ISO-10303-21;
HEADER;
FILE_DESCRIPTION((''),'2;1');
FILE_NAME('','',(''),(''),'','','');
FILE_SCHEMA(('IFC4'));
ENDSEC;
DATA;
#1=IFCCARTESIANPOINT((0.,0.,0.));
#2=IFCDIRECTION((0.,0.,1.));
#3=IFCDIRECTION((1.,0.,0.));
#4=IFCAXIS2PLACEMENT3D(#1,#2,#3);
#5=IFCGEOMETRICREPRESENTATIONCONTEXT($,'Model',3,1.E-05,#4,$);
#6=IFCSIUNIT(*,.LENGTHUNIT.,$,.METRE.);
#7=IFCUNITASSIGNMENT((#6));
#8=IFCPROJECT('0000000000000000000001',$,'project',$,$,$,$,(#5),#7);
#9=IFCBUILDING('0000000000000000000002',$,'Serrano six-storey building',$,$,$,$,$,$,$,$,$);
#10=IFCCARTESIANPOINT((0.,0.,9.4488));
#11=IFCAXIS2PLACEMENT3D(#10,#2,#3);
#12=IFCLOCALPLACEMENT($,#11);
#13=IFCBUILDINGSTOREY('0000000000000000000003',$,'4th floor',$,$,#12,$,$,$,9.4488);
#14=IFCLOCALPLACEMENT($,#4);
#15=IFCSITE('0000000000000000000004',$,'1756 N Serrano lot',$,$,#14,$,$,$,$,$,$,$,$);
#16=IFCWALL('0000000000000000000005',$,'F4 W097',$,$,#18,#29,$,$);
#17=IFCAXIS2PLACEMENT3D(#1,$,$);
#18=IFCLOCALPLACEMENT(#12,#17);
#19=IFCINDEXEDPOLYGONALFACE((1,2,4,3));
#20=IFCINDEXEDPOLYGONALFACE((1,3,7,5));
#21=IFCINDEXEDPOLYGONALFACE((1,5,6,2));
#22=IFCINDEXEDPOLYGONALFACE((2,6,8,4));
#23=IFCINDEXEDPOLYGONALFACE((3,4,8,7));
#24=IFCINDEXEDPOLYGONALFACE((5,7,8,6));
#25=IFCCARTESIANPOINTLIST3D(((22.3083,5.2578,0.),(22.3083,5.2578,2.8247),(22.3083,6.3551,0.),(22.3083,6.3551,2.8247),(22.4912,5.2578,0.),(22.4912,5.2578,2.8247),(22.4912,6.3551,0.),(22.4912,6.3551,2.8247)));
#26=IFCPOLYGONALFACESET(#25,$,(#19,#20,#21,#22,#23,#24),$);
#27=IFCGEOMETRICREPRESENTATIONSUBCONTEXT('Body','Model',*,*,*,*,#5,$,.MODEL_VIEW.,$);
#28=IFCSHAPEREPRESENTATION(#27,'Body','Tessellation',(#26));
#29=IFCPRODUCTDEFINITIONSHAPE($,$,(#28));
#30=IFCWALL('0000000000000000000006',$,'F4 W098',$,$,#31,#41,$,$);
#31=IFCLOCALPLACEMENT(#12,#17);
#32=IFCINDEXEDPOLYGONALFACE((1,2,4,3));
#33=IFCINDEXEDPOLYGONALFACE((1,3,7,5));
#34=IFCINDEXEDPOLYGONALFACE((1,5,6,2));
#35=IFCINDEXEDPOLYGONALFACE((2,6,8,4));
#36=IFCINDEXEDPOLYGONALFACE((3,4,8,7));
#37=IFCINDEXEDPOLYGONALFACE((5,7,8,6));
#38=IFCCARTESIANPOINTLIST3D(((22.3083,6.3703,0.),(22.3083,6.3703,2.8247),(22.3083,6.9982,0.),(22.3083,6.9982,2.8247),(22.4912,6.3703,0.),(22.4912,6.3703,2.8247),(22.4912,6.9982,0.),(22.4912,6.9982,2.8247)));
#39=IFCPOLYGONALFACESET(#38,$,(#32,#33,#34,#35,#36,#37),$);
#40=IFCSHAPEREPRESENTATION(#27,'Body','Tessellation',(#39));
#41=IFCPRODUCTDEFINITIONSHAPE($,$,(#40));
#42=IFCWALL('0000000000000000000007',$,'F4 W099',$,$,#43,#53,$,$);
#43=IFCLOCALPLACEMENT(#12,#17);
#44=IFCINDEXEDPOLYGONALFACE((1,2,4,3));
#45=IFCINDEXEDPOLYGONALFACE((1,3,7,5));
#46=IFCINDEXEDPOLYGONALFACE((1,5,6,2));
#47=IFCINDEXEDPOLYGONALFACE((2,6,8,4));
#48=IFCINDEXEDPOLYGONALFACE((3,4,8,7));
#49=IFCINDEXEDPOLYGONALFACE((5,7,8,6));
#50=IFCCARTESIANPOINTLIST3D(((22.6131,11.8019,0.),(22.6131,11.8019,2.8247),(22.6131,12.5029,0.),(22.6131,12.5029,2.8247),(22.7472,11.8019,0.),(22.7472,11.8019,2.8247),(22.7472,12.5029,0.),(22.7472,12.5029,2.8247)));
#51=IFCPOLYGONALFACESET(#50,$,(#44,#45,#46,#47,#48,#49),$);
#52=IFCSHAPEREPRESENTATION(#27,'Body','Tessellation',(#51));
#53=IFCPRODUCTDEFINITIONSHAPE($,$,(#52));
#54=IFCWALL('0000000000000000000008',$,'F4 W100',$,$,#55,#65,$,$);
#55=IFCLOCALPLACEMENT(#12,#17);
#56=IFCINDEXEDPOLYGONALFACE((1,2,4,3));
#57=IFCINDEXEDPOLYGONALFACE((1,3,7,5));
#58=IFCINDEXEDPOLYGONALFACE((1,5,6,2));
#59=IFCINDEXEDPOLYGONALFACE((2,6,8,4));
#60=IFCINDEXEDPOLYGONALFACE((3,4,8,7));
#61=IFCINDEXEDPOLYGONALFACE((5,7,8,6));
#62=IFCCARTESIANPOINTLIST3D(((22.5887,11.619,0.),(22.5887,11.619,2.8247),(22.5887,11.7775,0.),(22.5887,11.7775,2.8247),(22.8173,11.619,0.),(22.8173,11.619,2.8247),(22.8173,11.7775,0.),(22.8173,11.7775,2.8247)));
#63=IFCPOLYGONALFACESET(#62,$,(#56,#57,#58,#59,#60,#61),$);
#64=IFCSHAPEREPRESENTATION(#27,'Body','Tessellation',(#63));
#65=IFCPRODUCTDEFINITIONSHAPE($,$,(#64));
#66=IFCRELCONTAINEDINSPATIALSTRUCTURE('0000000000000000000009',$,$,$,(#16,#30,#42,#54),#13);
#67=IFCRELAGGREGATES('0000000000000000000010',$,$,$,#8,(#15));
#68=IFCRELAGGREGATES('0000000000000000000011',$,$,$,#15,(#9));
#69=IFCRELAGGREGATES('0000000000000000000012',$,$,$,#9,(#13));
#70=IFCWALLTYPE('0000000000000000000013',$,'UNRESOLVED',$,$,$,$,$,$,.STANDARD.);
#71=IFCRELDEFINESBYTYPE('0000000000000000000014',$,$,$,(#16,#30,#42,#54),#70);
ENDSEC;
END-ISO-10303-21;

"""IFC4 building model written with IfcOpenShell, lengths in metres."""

from ifc_helpers import new_model, si_unit, frame, origin_with_axes, place, context, subcontext, project, spatial, polyline, outline, extrude, type_object, element, save


model = new_model("IFC4")

# Units and contexts
model_context = context("Model", 3, precision=1e-05, world=origin_with_axes())
body_context = subcontext(model_context, "Body", "Model", "MODEL_VIEW")
ifc_project = project(units=[si_unit("LENGTHUNIT", "METRE")], contexts=[model_context])

# Site, building, storey
site_placement = place(None, origin_with_axes())
site = spatial("IfcSite", under=ifc_project, at=site_placement, Name="1756 N Serrano lot")
building = spatial("IfcBuilding", under=site, Name="Serrano six-storey building")
storey_placement = place(None, frame((0.0, 0.0, 9.4488), z_axis=(0.0, 0.0, 1.0), x_axis=(1.0, 0.0, 0.0)))
storey = spatial("IfcBuildingStorey", under=building, at=storey_placement, Name="4th floor", Elevation=9.4488)

# Walls
wall_type_1 = type_object("IfcWallType", Name="UNRESOLVED", PredefinedType="STANDARD")
wall_1_placement = place(storey_placement, frame((0.0, 0.0, -9.4488), z_axis=(0.0, 0.0, 1.0), x_axis=(1.0, 0.0, 0.0)))
element("IfcWall", 1, at=wall_1_placement, inside=storey, type_object=wall_type_1, Name="F4 W097", context=body_context, shape_type="SweptSolid", body=[
    extrude(outline(polyline([(22.3083, 6.3551), (22.4912, 6.3551), (22.4912, 5.2578), (22.3083, 5.2578), (22.3083, 6.3551)])), frame((0.0, 0.0, 9.4488)), (0.0, 0.0, 1.0), 2.8247),
])
wall_2_placement = place(storey_placement, frame((0.0, 0.0, -9.4488), z_axis=(0.0, 0.0, 1.0), x_axis=(1.0, 0.0, 0.0)))
element("IfcWall", 2, at=wall_2_placement, inside=storey, type_object=wall_type_1, Name="F4 W098", context=body_context, shape_type="SweptSolid", body=[
    extrude(outline(polyline([(22.3083, 6.9982), (22.4912, 6.9982), (22.4912, 6.3703), (22.3083, 6.3703), (22.3083, 6.9982)])), frame((0.0, 0.0, 9.4488)), (0.0, 0.0, 1.0), 2.8247),
])
wall_3_placement = place(storey_placement, frame((0.0, 0.0, -9.4488), z_axis=(0.0, 0.0, 1.0), x_axis=(1.0, 0.0, 0.0)))
element("IfcWall", 3, at=wall_3_placement, inside=storey, type_object=wall_type_1, Name="F4 W099", context=body_context, shape_type="SweptSolid", body=[
    extrude(outline(polyline([(22.6131, 12.5029), (22.7472, 12.5029), (22.7472, 11.8019), (22.6131, 11.8019), (22.6131, 12.5029)])), frame((0.0, 0.0, 9.4488)), (0.0, 0.0, 1.0), 2.8247),
])
wall_4_placement = place(storey_placement, frame((0.0, 0.0, -9.4488), z_axis=(0.0, 0.0, 1.0), x_axis=(1.0, 0.0, 0.0)))
element("IfcWall", 4, at=wall_4_placement, inside=storey, type_object=wall_type_1, Name="F4 W100", context=body_context, shape_type="SweptSolid", body=[
    extrude(outline(polyline([(22.5887, 11.7775), (22.8173, 11.7775), (22.8173, 11.619), (22.5887, 11.619), (22.5887, 11.7775)])), frame((0.0, 0.0, 9.4488)), (0.0, 0.0, 1.0), 2.8247),
])

save(model, "model.ifc")
